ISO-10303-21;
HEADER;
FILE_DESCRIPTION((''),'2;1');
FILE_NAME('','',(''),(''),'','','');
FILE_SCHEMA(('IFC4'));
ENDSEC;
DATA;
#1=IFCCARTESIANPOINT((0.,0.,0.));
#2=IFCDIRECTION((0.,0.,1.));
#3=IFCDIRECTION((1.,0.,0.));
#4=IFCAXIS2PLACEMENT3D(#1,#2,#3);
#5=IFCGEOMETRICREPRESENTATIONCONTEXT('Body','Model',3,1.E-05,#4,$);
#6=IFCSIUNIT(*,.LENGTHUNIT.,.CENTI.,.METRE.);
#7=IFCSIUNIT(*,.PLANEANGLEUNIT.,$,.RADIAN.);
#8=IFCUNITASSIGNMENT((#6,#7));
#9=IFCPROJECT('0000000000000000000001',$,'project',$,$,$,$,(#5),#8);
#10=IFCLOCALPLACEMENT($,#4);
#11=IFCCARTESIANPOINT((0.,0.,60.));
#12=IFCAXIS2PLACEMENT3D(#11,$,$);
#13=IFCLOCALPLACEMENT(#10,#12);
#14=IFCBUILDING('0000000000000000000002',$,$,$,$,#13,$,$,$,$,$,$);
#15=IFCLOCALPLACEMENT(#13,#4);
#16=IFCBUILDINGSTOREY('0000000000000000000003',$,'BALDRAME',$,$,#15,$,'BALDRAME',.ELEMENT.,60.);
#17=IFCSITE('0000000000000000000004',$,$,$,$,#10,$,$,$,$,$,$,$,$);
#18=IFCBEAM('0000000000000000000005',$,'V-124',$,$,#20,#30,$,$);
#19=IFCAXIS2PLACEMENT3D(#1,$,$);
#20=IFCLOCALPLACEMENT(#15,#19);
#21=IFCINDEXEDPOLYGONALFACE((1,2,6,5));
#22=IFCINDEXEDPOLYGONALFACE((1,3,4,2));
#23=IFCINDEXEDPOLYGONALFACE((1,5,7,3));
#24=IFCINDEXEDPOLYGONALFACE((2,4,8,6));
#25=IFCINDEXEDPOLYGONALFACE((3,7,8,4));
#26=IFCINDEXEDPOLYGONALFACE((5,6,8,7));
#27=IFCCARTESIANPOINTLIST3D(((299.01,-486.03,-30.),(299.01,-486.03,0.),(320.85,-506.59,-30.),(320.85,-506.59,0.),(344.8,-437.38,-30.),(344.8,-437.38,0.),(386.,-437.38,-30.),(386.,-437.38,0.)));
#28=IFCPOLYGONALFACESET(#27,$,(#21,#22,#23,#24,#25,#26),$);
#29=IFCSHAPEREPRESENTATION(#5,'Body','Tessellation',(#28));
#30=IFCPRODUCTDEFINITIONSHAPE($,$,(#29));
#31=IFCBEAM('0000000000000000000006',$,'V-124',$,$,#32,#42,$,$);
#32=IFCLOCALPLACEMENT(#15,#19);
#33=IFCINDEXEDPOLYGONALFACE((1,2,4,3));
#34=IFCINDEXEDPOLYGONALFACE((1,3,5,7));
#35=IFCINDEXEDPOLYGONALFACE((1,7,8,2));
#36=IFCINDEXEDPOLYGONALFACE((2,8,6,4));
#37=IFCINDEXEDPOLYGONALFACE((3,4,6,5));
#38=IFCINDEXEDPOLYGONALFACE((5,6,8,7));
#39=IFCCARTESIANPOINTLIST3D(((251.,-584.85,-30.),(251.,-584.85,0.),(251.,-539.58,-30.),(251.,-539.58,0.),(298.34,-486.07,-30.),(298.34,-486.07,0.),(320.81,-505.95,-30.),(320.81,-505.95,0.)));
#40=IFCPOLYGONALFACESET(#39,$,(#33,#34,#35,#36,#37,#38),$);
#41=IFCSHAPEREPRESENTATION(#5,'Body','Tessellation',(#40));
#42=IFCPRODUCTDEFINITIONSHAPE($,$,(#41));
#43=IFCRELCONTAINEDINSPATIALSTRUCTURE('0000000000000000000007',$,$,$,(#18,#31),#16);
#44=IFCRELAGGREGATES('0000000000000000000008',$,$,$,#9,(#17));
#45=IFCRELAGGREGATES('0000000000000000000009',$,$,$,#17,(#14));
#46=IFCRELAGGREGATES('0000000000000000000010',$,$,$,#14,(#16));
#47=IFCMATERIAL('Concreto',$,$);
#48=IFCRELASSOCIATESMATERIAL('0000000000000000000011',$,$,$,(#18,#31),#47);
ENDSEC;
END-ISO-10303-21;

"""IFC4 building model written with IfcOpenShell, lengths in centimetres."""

from ifc_helpers import new_model, si_unit, frame, origin_with_axes, origin_2d_with_axis, place, context, project, spatial, rectangle, extrude, clip, halfspace, material, element, save


model = new_model("IFC4")

# Units and contexts
model_context = context("Model", 3, precision=1e-05, world=origin_with_axes(), identifier="Body")
ifc_project = project(units=[si_unit("LENGTHUNIT", "METRE", prefix="CENTI"), si_unit("PLANEANGLEUNIT", "RADIAN")], contexts=[model_context])

# Site, building, storey
site_placement = place(None, origin_with_axes())
site = spatial("IfcSite", under=ifc_project, at=site_placement)
building_placement = place(site_placement, frame((0.0, 0.0, 60.0)))
building = spatial("IfcBuilding", under=site, at=building_placement)
storey_placement = place(building_placement, origin_with_axes())
storey = spatial("IfcBuildingStorey", under=building, at=storey_placement, Name="BALDRAME", LongName="BALDRAME", CompositionType="ELEMENT", Elevation=60.0)

# Shared definitions
ifc_material = material(Name="Concreto")

# Beams
beam_1_placement = place(storey_placement, frame((342.5, -471.99, 0.0), z_axis=(0.0, 0.0, 1.0), x_axis=(1.0, 0.0, 0.0)))
element("IfcBeam", 1, at=beam_1_placement, inside=storey, material=ifc_material, Name="V-124", context=model_context, shape_type="Clipping", body=[
    clip(extrude(rectangle(XDim=30.0, YDim=30.0, at=origin_2d_with_axis()), frame((-32.57, -24.33, -15.0), z_axis=(0.685387, 0.728179, 0.0), x_axis=(0.728179, -0.685387, 0.0)), (0.0, 0.0, 1.0), 95.05), halfspace(frame((2.3, 34.61, -30.0), z_axis=(0.0, -1.0, 0.0), x_axis=(0.0, 0.0, 0.685387)), True)),
])
beam_2_placement = place(storey_placement, frame((285.91, -535.46, 0.0), z_axis=(0.0, 0.0, 1.0), x_axis=(1.0, 0.0, 0.0)))
element("IfcBeam", 2, at=beam_2_placement, inside=storey, material=ifc_material, Name="V-124", context=model_context, shape_type="Clipping", body=[
    clip(extrude(rectangle(XDim=30.0, YDim=30.0, at=origin_2d_with_axis()), frame((-46.14, -39.45, -15.0), z_axis=(0.662629, 0.748948, 0.0), x_axis=(0.748948, -0.662629, 0.0)), (0.0, 0.0, 1.0), 105.36), halfspace(frame((-34.91, -4.12, 0.0), z_axis=(1.0, 0.0, 0.0), x_axis=(0.0, 0.0, 0.748948)), True)),
])

save(model, "model.ifc")
